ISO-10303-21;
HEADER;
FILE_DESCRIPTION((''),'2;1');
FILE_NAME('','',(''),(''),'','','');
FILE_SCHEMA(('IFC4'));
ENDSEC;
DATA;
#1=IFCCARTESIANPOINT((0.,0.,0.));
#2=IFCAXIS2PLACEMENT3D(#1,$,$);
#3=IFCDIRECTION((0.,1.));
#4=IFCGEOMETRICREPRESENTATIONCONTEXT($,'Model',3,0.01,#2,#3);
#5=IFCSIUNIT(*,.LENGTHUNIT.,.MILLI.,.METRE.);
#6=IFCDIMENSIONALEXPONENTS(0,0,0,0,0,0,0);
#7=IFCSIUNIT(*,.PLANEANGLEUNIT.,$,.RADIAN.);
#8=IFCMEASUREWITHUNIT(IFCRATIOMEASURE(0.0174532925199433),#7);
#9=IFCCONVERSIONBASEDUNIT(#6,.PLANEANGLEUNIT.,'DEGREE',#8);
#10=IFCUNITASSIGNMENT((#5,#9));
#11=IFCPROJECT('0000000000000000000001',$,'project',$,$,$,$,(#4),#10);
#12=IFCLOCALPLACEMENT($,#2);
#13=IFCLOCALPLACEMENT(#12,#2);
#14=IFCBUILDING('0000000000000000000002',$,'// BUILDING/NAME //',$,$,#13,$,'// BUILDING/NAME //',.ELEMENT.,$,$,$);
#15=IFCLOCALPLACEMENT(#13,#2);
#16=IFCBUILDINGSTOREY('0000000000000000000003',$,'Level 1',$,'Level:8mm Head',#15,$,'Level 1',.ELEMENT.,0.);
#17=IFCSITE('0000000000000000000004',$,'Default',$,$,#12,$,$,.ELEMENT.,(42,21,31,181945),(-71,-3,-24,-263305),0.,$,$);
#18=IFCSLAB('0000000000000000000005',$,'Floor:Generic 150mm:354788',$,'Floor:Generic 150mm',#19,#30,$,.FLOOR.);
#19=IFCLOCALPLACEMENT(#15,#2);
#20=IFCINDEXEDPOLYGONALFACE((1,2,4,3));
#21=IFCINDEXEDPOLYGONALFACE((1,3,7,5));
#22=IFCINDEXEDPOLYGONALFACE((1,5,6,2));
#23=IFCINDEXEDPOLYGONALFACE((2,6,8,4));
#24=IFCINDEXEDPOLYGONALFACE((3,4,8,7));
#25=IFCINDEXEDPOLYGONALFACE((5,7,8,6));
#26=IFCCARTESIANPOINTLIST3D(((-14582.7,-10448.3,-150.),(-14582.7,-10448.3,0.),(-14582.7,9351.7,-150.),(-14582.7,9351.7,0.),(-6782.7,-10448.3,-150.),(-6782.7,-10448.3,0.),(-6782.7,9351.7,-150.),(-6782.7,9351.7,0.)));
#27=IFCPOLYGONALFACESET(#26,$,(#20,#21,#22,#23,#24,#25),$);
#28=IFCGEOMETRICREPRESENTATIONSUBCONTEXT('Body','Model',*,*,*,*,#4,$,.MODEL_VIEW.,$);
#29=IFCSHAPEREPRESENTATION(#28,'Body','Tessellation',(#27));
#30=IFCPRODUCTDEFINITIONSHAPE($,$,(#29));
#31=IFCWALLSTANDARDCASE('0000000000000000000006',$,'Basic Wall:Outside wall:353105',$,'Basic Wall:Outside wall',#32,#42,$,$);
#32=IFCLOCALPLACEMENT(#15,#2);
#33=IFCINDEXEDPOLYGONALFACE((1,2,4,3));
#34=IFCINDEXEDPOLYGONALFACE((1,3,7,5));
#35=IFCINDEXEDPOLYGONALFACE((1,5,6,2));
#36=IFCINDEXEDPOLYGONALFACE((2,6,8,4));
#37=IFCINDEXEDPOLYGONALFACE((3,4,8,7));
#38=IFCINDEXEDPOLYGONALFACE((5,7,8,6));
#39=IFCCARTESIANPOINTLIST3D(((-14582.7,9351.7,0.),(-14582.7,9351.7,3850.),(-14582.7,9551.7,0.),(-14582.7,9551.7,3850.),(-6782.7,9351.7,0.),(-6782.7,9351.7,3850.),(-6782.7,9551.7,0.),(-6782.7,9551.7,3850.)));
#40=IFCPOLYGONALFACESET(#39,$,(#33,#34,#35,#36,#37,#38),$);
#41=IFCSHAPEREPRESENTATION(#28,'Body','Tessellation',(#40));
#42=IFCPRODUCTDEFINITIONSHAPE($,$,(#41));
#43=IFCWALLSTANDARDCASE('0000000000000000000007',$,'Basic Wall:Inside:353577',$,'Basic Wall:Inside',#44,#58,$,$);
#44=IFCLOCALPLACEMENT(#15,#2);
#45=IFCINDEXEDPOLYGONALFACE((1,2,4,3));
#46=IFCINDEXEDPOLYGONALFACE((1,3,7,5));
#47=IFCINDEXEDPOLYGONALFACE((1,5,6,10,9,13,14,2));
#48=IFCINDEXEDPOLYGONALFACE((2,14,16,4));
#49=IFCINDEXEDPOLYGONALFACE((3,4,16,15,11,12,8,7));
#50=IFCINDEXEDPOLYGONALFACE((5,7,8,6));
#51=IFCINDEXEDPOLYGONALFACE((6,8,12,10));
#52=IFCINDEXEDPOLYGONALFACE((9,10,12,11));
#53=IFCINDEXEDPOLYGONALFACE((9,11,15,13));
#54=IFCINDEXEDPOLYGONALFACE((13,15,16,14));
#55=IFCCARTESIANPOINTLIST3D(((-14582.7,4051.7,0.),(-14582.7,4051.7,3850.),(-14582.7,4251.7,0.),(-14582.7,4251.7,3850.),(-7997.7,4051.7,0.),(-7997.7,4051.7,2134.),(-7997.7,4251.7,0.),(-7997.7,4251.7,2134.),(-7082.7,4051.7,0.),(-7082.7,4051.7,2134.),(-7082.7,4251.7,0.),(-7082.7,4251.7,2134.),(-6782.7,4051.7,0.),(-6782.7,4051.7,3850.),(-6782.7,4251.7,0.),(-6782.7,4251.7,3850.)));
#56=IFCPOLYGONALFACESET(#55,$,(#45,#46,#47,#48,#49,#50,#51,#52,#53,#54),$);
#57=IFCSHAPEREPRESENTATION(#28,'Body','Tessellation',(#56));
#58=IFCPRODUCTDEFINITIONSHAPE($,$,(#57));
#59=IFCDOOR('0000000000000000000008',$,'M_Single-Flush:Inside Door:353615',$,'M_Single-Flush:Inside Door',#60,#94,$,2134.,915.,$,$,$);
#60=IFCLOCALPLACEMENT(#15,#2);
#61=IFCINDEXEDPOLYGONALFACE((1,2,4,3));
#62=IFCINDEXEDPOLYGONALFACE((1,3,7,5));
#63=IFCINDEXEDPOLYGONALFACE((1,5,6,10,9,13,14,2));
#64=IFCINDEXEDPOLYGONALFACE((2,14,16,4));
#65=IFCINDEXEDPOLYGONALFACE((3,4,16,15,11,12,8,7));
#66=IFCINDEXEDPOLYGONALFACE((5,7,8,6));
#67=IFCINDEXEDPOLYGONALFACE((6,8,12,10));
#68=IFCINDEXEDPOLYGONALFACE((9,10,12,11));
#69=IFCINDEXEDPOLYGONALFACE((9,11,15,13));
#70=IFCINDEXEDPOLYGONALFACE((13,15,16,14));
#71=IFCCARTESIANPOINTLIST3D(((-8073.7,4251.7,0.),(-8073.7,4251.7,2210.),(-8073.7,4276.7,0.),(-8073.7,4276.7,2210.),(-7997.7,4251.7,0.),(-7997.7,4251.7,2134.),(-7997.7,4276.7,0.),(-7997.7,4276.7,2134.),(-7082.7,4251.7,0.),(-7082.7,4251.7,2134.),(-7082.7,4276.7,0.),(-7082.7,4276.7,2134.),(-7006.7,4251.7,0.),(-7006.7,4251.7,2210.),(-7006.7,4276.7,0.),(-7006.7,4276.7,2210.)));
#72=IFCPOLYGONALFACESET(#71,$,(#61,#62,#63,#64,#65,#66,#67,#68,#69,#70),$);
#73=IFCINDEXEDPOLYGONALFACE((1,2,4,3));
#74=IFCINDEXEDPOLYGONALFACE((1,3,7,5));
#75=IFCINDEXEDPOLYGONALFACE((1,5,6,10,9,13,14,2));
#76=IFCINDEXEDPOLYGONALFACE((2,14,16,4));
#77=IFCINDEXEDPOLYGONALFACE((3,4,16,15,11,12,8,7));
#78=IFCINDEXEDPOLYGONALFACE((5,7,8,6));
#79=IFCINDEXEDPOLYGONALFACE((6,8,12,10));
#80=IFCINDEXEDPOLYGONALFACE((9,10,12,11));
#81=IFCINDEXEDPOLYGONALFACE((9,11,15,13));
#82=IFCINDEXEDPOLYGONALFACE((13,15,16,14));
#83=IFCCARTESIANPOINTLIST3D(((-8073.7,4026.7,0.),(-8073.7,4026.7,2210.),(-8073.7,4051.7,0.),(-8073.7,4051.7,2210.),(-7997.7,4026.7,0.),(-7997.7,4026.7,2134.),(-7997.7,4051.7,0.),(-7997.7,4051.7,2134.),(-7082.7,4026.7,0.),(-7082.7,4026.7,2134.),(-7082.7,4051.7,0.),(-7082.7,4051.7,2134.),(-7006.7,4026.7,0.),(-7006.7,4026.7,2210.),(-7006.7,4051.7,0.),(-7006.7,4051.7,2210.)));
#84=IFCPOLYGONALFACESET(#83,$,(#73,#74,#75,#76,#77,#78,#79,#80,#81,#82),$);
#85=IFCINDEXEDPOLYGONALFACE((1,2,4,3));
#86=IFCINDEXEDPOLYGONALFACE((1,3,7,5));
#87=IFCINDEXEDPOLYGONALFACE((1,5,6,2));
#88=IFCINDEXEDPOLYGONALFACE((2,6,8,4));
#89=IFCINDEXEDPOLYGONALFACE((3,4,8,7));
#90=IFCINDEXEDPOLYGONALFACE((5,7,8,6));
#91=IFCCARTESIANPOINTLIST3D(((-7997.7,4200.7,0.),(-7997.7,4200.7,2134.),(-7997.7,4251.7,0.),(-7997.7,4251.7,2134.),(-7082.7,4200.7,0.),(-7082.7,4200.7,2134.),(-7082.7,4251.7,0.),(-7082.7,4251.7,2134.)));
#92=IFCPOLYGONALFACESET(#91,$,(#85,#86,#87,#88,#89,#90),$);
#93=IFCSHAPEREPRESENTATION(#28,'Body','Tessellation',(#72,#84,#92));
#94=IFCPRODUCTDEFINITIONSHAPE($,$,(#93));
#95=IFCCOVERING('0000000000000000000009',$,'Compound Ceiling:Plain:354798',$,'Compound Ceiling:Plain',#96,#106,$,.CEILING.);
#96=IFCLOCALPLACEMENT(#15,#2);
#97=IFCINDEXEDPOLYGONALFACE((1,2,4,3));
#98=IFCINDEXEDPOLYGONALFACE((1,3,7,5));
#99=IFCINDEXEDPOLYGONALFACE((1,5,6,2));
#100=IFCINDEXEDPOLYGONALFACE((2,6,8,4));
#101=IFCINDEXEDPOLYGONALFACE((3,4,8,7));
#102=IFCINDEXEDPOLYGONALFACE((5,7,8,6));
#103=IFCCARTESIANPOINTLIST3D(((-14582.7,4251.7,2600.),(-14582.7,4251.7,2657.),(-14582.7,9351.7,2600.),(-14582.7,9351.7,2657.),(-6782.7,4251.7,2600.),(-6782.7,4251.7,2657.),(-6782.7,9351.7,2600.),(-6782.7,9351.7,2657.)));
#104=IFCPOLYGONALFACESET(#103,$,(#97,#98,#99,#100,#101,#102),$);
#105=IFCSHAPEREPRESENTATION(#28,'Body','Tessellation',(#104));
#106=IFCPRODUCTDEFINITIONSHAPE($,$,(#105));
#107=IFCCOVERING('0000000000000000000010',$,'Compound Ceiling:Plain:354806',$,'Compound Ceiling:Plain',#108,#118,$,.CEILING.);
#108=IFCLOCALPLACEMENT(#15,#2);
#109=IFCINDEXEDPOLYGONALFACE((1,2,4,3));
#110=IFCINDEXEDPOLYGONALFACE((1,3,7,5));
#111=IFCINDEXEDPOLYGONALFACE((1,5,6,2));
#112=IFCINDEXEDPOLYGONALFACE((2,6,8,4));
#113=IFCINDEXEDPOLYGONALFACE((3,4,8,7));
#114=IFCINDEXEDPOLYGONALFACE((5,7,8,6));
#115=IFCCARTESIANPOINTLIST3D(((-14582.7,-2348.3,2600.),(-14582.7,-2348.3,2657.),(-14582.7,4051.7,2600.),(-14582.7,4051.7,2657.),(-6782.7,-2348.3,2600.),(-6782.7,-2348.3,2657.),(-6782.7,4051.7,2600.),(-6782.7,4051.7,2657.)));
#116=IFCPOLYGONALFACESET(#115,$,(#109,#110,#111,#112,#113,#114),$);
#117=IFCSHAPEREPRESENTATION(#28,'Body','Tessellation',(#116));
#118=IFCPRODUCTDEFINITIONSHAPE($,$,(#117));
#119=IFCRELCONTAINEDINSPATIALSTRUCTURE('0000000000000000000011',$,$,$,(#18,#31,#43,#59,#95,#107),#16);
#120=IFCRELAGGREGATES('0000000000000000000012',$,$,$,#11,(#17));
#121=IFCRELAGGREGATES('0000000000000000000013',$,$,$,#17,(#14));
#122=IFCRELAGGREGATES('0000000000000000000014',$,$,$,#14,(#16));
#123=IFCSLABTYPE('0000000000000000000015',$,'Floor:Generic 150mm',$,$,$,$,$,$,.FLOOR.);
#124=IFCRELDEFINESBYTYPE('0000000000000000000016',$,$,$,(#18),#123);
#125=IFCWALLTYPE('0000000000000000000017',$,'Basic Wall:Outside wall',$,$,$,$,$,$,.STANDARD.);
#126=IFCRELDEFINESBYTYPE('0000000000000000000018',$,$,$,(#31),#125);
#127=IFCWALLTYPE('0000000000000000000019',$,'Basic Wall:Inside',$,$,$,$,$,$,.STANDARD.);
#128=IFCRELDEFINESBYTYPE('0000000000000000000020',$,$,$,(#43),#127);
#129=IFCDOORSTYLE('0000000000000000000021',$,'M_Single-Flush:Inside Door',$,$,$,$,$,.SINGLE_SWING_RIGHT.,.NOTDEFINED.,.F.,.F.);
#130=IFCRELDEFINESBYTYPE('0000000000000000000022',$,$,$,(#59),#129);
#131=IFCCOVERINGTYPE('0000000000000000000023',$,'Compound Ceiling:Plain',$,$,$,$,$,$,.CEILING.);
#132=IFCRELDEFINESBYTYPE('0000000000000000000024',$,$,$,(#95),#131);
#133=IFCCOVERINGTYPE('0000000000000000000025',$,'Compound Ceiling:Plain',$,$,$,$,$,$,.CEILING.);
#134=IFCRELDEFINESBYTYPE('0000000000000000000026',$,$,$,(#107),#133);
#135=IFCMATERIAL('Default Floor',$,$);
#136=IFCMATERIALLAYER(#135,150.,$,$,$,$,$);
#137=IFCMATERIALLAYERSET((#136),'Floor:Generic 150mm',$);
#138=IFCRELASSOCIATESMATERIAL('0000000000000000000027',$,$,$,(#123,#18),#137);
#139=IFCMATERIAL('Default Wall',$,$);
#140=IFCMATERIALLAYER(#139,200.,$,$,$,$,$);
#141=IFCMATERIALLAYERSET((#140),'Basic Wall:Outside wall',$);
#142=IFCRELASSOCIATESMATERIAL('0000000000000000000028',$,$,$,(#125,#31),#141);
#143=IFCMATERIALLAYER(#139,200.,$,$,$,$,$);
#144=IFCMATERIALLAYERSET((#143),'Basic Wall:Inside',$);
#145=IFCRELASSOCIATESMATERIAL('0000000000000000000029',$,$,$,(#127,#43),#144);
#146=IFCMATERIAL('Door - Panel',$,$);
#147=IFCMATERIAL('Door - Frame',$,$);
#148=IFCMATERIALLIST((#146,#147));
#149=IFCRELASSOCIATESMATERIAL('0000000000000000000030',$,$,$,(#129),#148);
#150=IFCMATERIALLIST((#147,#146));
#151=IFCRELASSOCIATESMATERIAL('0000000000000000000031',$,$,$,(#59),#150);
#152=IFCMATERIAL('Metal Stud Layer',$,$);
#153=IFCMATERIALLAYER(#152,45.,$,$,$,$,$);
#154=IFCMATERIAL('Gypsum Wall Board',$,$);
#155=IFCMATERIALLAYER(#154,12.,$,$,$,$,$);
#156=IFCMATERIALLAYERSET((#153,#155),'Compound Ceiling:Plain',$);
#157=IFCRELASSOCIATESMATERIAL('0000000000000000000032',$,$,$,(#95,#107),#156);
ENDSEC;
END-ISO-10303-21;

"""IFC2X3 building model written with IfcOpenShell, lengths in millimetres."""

from ifc_helpers import new_model, entity, si_unit, converted_unit, direction, frame, frame_2d, origin, place, context, subcontext, project, spatial, polyline, rectangle, outline, extrude, clip, bounded_halfspace, source, transform, mapped, material, material_list, layer, layer_set, layer_usage, type_object, type_shapes, element, fill, save


model = new_model("IFC2X3")

# Units and contexts
model_context = context("Model", 3, precision=0.01, world=origin(), true_north=direction((0.0, 1.0)))
body_context = subcontext(model_context, "Body", "Model", "MODEL_VIEW")
ifc_project = project(units=[si_unit("LENGTHUNIT", "METRE", prefix="MILLI"), converted_unit("PLANEANGLEUNIT", "DEGREE", entity("IfcRatioMeasure", 0.0174532925199433), si_unit("PLANEANGLEUNIT", "RADIAN"), dimensions=[0, 0, 0, 0, 0, 0, 0])], contexts=[model_context])

# Site, building, storey
site_placement = place(None, origin())
site = spatial("IfcSite", under=ifc_project, at=site_placement, Name="Default", CompositionType="ELEMENT", RefLatitude=(42, 21, 31, 181945), RefLongitude=(-71, -3, -24, -263305), RefElevation=0.0)
building_placement = place(site_placement, origin())
building = spatial("IfcBuilding", under=site, at=building_placement, Name="// BUILDING/NAME //", LongName="// BUILDING/NAME //", CompositionType="ELEMENT")
storey_placement = place(building_placement, origin())
storey = spatial("IfcBuildingStorey", under=building, at=storey_placement, Name="Level 1", ObjectType="Level:8mm Head", LongName="Level 1", CompositionType="ELEMENT", Elevation=0.0)

# Slab
ifc_material_1 = material(Name="Default Floor")
ifc_layer_1 = layer(ifc_material_1, 150.0)
ifc_layer_set_1 = layer_set([ifc_layer_1], Name="Floor:Generic 150mm")
ifc_layer_usage_1 = layer_usage(ifc_layer_set_1, "AXIS3", "POSITIVE", 0.0)
slab_type = type_object("IfcSlabType", Name="Floor:Generic 150mm", PredefinedType="FLOOR", material=ifc_layer_set_1)
slab_placement = place(storey_placement, origin())
element("IfcSlab", 1, at=slab_placement, inside=storey, type_object=slab_type, material=ifc_layer_usage_1, Name="Floor:Generic 150mm:354788", ObjectType="Floor:Generic 150mm", PredefinedType="FLOOR", context=body_context, shape_type="SweptSolid", body=[
    extrude(rectangle(XDim=19800.0, YDim=7800.0, at=frame_2d((0.0, 0.0), x_axis=(1.0, 0.0))), frame((-10682.7, -548.3, 0.0), z_axis=(0.0, 0.0, -1.0), x_axis=(0.0, 1.0, 0.0)), (0.0, 0.0, 1.0), 150.0),
])

# Wall
ifc_material_2 = material(Name="Default Wall")
ifc_layer_2 = layer(ifc_material_2, 200.0)
ifc_layer_set_2 = layer_set([ifc_layer_2], Name="Basic Wall:Outside wall")
ifc_layer_usage_2 = layer_usage(ifc_layer_set_2, "AXIS2", "NEGATIVE", 100.0)
wall_type_1 = type_object("IfcWallType", Name="Basic Wall:Outside wall", PredefinedType="STANDARD", material=ifc_layer_set_2)
wall_1_placement = place(storey_placement, frame((-6782.7, 9451.7, 0.0), z_axis=(0.0, 0.0, 1.0), x_axis=(-1.0, 0.0, 0.0)))
element("IfcWallStandardCase", 2, at=wall_1_placement, inside=storey, type_object=wall_type_1, material=ifc_layer_usage_2, Name="Basic Wall:Outside wall:353105", ObjectType="Basic Wall:Outside wall", context=body_context, shape_type="Clipping", body=[
    clip(extrude(rectangle(XDim=7800.0, YDim=200.0, at=frame_2d((3900.0, 0.0), x_axis=(-1.0, 0.0))), origin(), (0.0, 0.0, 1.0), 3850.0), bounded_halfspace(frame((0.0, -100.0, 3850.0), z_axis=(0.0, 0.0, -1.0), x_axis=(-1.0, 0.0, 0.0)), True, frame((0.0, -100.0, 3850.0)), polyline([(0.0, 0.0), (7800.0, 0.0), (7800.0, 200.0), (0.0, 200.0), (0.0, 0.0)]))),
])

# Wall, opening, door
ifc_layer_3 = layer(ifc_material_2, 200.0)
ifc_layer_set_3 = layer_set([ifc_layer_3], Name="Basic Wall:Inside")
ifc_layer_usage_3 = layer_usage(ifc_layer_set_3, "AXIS2", "NEGATIVE", 100.0)
wall_type_2 = type_object("IfcWallType", Name="Basic Wall:Inside", PredefinedType="STANDARD", material=ifc_layer_set_3)
wall_2_placement = place(storey_placement, frame((-14582.7, 4151.7, 0.0)))
wall_2 = element("IfcWallStandardCase", 3, at=wall_2_placement, inside=storey, type_object=wall_type_2, material=ifc_layer_usage_3, Name="Basic Wall:Inside:353577", ObjectType="Basic Wall:Inside", context=body_context, shape_type="Clipping", body=[
    clip(extrude(rectangle(XDim=7800.0, YDim=200.0, at=frame_2d((3900.0, 0.0), x_axis=(-1.0, 0.0))), origin(), (0.0, 0.0, 1.0), 3850.0), bounded_halfspace(frame((0.0, -100.0, 3850.0), z_axis=(0.0, 0.0, -1.0), x_axis=(1.0, 0.0, 0.0)), True, frame((0.0, -100.0, 3850.0)), polyline([(0.0, 0.0), (7800.0, 0.0), (7800.0, 200.0), (0.0, 200.0), (0.0, 0.0)]))),
])
opening_placement = place(wall_2_placement, frame((6585.0, -100.0, 0.0)))
opening = element("IfcOpeningElement", 4, at=opening_placement, cuts=wall_2, ObjectType="Opening", context=body_context, shape_type="SweptSolid", body=[
    extrude(rectangle(XDim=915.0, YDim=2134.0, at=frame_2d((1067.0, 457.5), x_axis=(0.0, 1.0))), frame((0.0, 0.0, 0.0), z_axis=(0.0, 1.0, 0.0), x_axis=(0.0, 0.0, 1.0)), (0.0, 0.0, 1.0), 200.0),
])
ifc_material_3 = material(Name="Door - Frame")
ifc_material_4 = material(Name="Door - Panel")
ifc_material_list_1 = material_list([ifc_material_3, ifc_material_4])
ifc_material_list_2 = material_list([ifc_material_4, ifc_material_3])
door_style = type_object("IfcDoorStyle", Name="M_Single-Flush:Inside Door", ConstructionType="NOTDEFINED", OperationType="SINGLE_SWING_RIGHT", ParameterTakesPrecedence=False, Sizeable=False, material=ifc_material_list_2)
shared_shape = source(origin(), body_context, "Body", "SweptSolid", [
    extrude(outline(polyline([(-533.5, -1124.0), (533.5, -1124.0), (533.5, 1086.0), (457.5, 1086.0), (457.5, -1048.0), (-457.5, -1048.0), (-457.5, 1086.0), (-533.5, 1086.0), (-533.5, -1124.0)])), frame((457.5, 200.0, 1086.0), z_axis=(0.0, 1.0, 0.0), x_axis=(1.0, 0.0, 0.0)), (0.0, 0.0, 1.0), 25.0),
    extrude(outline(polyline([(-1124.0, -533.5), (1086.0, -533.5), (1086.0, -457.5), (-1048.0, -457.5), (-1048.0, 457.5), (1086.0, 457.5), (1086.0, 533.5), (-1124.0, 533.5), (-1124.0, -533.5)])), frame((457.5, -25.0, 1086.0), z_axis=(0.0, 1.0, 0.0), x_axis=(0.0, 0.0, -1.0)), (0.0, 0.0, 1.0), 25.0),
    extrude(rectangle(XDim=51.0, YDim=915.0, at=frame_2d((0.0, 0.0), x_axis=(1.0, 0.0))), frame((457.5, 174.5, 0.0), z_axis=(0.0, 0.0, 1.0), x_axis=(0.0, 1.0, 0.0)), (0.0, 0.0, 1.0), 2134.0),
])
type_shapes(door_style, [shared_shape])
door_placement = place(opening_placement, origin())
door = element("IfcDoor", 5, at=door_placement, inside=storey, type_object=door_style, material=ifc_material_list_1, Name="M_Single-Flush:Inside Door:353615", ObjectType="M_Single-Flush:Inside Door", OverallHeight=2134.0, OverallWidth=915.0, context=body_context, shape_type="MappedRepresentation", body=[
    mapped(shared_shape, transform((0.0, 0.0, 0.0), scale=1.0)),
])
fill(opening, door)

# Coverings
ifc_material_5 = material(Name="Metal Stud Layer")
ifc_layer_4 = layer(ifc_material_5, 45.0)
ifc_material_6 = material(Name="Gypsum Wall Board")
ifc_layer_5 = layer(ifc_material_6, 12.0)
ifc_layer_set_4 = layer_set([ifc_layer_4, ifc_layer_5], Name="Compound Ceiling:Plain")
ifc_layer_usage_4 = layer_usage(ifc_layer_set_4, "AXIS3", "POSITIVE", 0.0)
covering_type_1 = type_object("IfcCoveringType", Name="Compound Ceiling:Plain", PredefinedType="CEILING")
covering_1_placement = place(storey_placement, origin())
element("IfcCovering", 6, at=covering_1_placement, inside=storey, type_object=covering_type_1, material=ifc_layer_usage_4, Name="Compound Ceiling:Plain:354798", ObjectType="Compound Ceiling:Plain", PredefinedType="CEILING", context=body_context, shape_type="SweptSolid", body=[
    extrude(rectangle(XDim=5100.0, YDim=7800.0, at=frame_2d((0.0, 0.0), x_axis=(1.0, 0.0))), frame((-10682.7, 6801.7, 2600.0), z_axis=(0.0, 0.0, 1.0), x_axis=(0.0, 1.0, 0.0)), (0.0, 0.0, 1.0), 57.0),
])
ifc_layer_usage_5 = layer_usage(ifc_layer_set_4, "AXIS3", "POSITIVE", 0.0)
covering_type_2 = type_object("IfcCoveringType", Name="Compound Ceiling:Plain", PredefinedType="CEILING")
covering_2_placement = place(storey_placement, origin())
element("IfcCovering", 7, at=covering_2_placement, inside=storey, type_object=covering_type_2, material=ifc_layer_usage_5, Name="Compound Ceiling:Plain:354806", ObjectType="Compound Ceiling:Plain", PredefinedType="CEILING", context=body_context, shape_type="SweptSolid", body=[
    extrude(rectangle(XDim=6400.0, YDim=7800.0, at=frame_2d((0.0, 0.0), x_axis=(1.0, 0.0))), frame((-10682.7, 851.7, 2600.0), z_axis=(0.0, 0.0, 1.0), x_axis=(0.0, 1.0, 0.0)), (0.0, 0.0, 1.0), 57.0),
])

save(model, "model.ifc")
